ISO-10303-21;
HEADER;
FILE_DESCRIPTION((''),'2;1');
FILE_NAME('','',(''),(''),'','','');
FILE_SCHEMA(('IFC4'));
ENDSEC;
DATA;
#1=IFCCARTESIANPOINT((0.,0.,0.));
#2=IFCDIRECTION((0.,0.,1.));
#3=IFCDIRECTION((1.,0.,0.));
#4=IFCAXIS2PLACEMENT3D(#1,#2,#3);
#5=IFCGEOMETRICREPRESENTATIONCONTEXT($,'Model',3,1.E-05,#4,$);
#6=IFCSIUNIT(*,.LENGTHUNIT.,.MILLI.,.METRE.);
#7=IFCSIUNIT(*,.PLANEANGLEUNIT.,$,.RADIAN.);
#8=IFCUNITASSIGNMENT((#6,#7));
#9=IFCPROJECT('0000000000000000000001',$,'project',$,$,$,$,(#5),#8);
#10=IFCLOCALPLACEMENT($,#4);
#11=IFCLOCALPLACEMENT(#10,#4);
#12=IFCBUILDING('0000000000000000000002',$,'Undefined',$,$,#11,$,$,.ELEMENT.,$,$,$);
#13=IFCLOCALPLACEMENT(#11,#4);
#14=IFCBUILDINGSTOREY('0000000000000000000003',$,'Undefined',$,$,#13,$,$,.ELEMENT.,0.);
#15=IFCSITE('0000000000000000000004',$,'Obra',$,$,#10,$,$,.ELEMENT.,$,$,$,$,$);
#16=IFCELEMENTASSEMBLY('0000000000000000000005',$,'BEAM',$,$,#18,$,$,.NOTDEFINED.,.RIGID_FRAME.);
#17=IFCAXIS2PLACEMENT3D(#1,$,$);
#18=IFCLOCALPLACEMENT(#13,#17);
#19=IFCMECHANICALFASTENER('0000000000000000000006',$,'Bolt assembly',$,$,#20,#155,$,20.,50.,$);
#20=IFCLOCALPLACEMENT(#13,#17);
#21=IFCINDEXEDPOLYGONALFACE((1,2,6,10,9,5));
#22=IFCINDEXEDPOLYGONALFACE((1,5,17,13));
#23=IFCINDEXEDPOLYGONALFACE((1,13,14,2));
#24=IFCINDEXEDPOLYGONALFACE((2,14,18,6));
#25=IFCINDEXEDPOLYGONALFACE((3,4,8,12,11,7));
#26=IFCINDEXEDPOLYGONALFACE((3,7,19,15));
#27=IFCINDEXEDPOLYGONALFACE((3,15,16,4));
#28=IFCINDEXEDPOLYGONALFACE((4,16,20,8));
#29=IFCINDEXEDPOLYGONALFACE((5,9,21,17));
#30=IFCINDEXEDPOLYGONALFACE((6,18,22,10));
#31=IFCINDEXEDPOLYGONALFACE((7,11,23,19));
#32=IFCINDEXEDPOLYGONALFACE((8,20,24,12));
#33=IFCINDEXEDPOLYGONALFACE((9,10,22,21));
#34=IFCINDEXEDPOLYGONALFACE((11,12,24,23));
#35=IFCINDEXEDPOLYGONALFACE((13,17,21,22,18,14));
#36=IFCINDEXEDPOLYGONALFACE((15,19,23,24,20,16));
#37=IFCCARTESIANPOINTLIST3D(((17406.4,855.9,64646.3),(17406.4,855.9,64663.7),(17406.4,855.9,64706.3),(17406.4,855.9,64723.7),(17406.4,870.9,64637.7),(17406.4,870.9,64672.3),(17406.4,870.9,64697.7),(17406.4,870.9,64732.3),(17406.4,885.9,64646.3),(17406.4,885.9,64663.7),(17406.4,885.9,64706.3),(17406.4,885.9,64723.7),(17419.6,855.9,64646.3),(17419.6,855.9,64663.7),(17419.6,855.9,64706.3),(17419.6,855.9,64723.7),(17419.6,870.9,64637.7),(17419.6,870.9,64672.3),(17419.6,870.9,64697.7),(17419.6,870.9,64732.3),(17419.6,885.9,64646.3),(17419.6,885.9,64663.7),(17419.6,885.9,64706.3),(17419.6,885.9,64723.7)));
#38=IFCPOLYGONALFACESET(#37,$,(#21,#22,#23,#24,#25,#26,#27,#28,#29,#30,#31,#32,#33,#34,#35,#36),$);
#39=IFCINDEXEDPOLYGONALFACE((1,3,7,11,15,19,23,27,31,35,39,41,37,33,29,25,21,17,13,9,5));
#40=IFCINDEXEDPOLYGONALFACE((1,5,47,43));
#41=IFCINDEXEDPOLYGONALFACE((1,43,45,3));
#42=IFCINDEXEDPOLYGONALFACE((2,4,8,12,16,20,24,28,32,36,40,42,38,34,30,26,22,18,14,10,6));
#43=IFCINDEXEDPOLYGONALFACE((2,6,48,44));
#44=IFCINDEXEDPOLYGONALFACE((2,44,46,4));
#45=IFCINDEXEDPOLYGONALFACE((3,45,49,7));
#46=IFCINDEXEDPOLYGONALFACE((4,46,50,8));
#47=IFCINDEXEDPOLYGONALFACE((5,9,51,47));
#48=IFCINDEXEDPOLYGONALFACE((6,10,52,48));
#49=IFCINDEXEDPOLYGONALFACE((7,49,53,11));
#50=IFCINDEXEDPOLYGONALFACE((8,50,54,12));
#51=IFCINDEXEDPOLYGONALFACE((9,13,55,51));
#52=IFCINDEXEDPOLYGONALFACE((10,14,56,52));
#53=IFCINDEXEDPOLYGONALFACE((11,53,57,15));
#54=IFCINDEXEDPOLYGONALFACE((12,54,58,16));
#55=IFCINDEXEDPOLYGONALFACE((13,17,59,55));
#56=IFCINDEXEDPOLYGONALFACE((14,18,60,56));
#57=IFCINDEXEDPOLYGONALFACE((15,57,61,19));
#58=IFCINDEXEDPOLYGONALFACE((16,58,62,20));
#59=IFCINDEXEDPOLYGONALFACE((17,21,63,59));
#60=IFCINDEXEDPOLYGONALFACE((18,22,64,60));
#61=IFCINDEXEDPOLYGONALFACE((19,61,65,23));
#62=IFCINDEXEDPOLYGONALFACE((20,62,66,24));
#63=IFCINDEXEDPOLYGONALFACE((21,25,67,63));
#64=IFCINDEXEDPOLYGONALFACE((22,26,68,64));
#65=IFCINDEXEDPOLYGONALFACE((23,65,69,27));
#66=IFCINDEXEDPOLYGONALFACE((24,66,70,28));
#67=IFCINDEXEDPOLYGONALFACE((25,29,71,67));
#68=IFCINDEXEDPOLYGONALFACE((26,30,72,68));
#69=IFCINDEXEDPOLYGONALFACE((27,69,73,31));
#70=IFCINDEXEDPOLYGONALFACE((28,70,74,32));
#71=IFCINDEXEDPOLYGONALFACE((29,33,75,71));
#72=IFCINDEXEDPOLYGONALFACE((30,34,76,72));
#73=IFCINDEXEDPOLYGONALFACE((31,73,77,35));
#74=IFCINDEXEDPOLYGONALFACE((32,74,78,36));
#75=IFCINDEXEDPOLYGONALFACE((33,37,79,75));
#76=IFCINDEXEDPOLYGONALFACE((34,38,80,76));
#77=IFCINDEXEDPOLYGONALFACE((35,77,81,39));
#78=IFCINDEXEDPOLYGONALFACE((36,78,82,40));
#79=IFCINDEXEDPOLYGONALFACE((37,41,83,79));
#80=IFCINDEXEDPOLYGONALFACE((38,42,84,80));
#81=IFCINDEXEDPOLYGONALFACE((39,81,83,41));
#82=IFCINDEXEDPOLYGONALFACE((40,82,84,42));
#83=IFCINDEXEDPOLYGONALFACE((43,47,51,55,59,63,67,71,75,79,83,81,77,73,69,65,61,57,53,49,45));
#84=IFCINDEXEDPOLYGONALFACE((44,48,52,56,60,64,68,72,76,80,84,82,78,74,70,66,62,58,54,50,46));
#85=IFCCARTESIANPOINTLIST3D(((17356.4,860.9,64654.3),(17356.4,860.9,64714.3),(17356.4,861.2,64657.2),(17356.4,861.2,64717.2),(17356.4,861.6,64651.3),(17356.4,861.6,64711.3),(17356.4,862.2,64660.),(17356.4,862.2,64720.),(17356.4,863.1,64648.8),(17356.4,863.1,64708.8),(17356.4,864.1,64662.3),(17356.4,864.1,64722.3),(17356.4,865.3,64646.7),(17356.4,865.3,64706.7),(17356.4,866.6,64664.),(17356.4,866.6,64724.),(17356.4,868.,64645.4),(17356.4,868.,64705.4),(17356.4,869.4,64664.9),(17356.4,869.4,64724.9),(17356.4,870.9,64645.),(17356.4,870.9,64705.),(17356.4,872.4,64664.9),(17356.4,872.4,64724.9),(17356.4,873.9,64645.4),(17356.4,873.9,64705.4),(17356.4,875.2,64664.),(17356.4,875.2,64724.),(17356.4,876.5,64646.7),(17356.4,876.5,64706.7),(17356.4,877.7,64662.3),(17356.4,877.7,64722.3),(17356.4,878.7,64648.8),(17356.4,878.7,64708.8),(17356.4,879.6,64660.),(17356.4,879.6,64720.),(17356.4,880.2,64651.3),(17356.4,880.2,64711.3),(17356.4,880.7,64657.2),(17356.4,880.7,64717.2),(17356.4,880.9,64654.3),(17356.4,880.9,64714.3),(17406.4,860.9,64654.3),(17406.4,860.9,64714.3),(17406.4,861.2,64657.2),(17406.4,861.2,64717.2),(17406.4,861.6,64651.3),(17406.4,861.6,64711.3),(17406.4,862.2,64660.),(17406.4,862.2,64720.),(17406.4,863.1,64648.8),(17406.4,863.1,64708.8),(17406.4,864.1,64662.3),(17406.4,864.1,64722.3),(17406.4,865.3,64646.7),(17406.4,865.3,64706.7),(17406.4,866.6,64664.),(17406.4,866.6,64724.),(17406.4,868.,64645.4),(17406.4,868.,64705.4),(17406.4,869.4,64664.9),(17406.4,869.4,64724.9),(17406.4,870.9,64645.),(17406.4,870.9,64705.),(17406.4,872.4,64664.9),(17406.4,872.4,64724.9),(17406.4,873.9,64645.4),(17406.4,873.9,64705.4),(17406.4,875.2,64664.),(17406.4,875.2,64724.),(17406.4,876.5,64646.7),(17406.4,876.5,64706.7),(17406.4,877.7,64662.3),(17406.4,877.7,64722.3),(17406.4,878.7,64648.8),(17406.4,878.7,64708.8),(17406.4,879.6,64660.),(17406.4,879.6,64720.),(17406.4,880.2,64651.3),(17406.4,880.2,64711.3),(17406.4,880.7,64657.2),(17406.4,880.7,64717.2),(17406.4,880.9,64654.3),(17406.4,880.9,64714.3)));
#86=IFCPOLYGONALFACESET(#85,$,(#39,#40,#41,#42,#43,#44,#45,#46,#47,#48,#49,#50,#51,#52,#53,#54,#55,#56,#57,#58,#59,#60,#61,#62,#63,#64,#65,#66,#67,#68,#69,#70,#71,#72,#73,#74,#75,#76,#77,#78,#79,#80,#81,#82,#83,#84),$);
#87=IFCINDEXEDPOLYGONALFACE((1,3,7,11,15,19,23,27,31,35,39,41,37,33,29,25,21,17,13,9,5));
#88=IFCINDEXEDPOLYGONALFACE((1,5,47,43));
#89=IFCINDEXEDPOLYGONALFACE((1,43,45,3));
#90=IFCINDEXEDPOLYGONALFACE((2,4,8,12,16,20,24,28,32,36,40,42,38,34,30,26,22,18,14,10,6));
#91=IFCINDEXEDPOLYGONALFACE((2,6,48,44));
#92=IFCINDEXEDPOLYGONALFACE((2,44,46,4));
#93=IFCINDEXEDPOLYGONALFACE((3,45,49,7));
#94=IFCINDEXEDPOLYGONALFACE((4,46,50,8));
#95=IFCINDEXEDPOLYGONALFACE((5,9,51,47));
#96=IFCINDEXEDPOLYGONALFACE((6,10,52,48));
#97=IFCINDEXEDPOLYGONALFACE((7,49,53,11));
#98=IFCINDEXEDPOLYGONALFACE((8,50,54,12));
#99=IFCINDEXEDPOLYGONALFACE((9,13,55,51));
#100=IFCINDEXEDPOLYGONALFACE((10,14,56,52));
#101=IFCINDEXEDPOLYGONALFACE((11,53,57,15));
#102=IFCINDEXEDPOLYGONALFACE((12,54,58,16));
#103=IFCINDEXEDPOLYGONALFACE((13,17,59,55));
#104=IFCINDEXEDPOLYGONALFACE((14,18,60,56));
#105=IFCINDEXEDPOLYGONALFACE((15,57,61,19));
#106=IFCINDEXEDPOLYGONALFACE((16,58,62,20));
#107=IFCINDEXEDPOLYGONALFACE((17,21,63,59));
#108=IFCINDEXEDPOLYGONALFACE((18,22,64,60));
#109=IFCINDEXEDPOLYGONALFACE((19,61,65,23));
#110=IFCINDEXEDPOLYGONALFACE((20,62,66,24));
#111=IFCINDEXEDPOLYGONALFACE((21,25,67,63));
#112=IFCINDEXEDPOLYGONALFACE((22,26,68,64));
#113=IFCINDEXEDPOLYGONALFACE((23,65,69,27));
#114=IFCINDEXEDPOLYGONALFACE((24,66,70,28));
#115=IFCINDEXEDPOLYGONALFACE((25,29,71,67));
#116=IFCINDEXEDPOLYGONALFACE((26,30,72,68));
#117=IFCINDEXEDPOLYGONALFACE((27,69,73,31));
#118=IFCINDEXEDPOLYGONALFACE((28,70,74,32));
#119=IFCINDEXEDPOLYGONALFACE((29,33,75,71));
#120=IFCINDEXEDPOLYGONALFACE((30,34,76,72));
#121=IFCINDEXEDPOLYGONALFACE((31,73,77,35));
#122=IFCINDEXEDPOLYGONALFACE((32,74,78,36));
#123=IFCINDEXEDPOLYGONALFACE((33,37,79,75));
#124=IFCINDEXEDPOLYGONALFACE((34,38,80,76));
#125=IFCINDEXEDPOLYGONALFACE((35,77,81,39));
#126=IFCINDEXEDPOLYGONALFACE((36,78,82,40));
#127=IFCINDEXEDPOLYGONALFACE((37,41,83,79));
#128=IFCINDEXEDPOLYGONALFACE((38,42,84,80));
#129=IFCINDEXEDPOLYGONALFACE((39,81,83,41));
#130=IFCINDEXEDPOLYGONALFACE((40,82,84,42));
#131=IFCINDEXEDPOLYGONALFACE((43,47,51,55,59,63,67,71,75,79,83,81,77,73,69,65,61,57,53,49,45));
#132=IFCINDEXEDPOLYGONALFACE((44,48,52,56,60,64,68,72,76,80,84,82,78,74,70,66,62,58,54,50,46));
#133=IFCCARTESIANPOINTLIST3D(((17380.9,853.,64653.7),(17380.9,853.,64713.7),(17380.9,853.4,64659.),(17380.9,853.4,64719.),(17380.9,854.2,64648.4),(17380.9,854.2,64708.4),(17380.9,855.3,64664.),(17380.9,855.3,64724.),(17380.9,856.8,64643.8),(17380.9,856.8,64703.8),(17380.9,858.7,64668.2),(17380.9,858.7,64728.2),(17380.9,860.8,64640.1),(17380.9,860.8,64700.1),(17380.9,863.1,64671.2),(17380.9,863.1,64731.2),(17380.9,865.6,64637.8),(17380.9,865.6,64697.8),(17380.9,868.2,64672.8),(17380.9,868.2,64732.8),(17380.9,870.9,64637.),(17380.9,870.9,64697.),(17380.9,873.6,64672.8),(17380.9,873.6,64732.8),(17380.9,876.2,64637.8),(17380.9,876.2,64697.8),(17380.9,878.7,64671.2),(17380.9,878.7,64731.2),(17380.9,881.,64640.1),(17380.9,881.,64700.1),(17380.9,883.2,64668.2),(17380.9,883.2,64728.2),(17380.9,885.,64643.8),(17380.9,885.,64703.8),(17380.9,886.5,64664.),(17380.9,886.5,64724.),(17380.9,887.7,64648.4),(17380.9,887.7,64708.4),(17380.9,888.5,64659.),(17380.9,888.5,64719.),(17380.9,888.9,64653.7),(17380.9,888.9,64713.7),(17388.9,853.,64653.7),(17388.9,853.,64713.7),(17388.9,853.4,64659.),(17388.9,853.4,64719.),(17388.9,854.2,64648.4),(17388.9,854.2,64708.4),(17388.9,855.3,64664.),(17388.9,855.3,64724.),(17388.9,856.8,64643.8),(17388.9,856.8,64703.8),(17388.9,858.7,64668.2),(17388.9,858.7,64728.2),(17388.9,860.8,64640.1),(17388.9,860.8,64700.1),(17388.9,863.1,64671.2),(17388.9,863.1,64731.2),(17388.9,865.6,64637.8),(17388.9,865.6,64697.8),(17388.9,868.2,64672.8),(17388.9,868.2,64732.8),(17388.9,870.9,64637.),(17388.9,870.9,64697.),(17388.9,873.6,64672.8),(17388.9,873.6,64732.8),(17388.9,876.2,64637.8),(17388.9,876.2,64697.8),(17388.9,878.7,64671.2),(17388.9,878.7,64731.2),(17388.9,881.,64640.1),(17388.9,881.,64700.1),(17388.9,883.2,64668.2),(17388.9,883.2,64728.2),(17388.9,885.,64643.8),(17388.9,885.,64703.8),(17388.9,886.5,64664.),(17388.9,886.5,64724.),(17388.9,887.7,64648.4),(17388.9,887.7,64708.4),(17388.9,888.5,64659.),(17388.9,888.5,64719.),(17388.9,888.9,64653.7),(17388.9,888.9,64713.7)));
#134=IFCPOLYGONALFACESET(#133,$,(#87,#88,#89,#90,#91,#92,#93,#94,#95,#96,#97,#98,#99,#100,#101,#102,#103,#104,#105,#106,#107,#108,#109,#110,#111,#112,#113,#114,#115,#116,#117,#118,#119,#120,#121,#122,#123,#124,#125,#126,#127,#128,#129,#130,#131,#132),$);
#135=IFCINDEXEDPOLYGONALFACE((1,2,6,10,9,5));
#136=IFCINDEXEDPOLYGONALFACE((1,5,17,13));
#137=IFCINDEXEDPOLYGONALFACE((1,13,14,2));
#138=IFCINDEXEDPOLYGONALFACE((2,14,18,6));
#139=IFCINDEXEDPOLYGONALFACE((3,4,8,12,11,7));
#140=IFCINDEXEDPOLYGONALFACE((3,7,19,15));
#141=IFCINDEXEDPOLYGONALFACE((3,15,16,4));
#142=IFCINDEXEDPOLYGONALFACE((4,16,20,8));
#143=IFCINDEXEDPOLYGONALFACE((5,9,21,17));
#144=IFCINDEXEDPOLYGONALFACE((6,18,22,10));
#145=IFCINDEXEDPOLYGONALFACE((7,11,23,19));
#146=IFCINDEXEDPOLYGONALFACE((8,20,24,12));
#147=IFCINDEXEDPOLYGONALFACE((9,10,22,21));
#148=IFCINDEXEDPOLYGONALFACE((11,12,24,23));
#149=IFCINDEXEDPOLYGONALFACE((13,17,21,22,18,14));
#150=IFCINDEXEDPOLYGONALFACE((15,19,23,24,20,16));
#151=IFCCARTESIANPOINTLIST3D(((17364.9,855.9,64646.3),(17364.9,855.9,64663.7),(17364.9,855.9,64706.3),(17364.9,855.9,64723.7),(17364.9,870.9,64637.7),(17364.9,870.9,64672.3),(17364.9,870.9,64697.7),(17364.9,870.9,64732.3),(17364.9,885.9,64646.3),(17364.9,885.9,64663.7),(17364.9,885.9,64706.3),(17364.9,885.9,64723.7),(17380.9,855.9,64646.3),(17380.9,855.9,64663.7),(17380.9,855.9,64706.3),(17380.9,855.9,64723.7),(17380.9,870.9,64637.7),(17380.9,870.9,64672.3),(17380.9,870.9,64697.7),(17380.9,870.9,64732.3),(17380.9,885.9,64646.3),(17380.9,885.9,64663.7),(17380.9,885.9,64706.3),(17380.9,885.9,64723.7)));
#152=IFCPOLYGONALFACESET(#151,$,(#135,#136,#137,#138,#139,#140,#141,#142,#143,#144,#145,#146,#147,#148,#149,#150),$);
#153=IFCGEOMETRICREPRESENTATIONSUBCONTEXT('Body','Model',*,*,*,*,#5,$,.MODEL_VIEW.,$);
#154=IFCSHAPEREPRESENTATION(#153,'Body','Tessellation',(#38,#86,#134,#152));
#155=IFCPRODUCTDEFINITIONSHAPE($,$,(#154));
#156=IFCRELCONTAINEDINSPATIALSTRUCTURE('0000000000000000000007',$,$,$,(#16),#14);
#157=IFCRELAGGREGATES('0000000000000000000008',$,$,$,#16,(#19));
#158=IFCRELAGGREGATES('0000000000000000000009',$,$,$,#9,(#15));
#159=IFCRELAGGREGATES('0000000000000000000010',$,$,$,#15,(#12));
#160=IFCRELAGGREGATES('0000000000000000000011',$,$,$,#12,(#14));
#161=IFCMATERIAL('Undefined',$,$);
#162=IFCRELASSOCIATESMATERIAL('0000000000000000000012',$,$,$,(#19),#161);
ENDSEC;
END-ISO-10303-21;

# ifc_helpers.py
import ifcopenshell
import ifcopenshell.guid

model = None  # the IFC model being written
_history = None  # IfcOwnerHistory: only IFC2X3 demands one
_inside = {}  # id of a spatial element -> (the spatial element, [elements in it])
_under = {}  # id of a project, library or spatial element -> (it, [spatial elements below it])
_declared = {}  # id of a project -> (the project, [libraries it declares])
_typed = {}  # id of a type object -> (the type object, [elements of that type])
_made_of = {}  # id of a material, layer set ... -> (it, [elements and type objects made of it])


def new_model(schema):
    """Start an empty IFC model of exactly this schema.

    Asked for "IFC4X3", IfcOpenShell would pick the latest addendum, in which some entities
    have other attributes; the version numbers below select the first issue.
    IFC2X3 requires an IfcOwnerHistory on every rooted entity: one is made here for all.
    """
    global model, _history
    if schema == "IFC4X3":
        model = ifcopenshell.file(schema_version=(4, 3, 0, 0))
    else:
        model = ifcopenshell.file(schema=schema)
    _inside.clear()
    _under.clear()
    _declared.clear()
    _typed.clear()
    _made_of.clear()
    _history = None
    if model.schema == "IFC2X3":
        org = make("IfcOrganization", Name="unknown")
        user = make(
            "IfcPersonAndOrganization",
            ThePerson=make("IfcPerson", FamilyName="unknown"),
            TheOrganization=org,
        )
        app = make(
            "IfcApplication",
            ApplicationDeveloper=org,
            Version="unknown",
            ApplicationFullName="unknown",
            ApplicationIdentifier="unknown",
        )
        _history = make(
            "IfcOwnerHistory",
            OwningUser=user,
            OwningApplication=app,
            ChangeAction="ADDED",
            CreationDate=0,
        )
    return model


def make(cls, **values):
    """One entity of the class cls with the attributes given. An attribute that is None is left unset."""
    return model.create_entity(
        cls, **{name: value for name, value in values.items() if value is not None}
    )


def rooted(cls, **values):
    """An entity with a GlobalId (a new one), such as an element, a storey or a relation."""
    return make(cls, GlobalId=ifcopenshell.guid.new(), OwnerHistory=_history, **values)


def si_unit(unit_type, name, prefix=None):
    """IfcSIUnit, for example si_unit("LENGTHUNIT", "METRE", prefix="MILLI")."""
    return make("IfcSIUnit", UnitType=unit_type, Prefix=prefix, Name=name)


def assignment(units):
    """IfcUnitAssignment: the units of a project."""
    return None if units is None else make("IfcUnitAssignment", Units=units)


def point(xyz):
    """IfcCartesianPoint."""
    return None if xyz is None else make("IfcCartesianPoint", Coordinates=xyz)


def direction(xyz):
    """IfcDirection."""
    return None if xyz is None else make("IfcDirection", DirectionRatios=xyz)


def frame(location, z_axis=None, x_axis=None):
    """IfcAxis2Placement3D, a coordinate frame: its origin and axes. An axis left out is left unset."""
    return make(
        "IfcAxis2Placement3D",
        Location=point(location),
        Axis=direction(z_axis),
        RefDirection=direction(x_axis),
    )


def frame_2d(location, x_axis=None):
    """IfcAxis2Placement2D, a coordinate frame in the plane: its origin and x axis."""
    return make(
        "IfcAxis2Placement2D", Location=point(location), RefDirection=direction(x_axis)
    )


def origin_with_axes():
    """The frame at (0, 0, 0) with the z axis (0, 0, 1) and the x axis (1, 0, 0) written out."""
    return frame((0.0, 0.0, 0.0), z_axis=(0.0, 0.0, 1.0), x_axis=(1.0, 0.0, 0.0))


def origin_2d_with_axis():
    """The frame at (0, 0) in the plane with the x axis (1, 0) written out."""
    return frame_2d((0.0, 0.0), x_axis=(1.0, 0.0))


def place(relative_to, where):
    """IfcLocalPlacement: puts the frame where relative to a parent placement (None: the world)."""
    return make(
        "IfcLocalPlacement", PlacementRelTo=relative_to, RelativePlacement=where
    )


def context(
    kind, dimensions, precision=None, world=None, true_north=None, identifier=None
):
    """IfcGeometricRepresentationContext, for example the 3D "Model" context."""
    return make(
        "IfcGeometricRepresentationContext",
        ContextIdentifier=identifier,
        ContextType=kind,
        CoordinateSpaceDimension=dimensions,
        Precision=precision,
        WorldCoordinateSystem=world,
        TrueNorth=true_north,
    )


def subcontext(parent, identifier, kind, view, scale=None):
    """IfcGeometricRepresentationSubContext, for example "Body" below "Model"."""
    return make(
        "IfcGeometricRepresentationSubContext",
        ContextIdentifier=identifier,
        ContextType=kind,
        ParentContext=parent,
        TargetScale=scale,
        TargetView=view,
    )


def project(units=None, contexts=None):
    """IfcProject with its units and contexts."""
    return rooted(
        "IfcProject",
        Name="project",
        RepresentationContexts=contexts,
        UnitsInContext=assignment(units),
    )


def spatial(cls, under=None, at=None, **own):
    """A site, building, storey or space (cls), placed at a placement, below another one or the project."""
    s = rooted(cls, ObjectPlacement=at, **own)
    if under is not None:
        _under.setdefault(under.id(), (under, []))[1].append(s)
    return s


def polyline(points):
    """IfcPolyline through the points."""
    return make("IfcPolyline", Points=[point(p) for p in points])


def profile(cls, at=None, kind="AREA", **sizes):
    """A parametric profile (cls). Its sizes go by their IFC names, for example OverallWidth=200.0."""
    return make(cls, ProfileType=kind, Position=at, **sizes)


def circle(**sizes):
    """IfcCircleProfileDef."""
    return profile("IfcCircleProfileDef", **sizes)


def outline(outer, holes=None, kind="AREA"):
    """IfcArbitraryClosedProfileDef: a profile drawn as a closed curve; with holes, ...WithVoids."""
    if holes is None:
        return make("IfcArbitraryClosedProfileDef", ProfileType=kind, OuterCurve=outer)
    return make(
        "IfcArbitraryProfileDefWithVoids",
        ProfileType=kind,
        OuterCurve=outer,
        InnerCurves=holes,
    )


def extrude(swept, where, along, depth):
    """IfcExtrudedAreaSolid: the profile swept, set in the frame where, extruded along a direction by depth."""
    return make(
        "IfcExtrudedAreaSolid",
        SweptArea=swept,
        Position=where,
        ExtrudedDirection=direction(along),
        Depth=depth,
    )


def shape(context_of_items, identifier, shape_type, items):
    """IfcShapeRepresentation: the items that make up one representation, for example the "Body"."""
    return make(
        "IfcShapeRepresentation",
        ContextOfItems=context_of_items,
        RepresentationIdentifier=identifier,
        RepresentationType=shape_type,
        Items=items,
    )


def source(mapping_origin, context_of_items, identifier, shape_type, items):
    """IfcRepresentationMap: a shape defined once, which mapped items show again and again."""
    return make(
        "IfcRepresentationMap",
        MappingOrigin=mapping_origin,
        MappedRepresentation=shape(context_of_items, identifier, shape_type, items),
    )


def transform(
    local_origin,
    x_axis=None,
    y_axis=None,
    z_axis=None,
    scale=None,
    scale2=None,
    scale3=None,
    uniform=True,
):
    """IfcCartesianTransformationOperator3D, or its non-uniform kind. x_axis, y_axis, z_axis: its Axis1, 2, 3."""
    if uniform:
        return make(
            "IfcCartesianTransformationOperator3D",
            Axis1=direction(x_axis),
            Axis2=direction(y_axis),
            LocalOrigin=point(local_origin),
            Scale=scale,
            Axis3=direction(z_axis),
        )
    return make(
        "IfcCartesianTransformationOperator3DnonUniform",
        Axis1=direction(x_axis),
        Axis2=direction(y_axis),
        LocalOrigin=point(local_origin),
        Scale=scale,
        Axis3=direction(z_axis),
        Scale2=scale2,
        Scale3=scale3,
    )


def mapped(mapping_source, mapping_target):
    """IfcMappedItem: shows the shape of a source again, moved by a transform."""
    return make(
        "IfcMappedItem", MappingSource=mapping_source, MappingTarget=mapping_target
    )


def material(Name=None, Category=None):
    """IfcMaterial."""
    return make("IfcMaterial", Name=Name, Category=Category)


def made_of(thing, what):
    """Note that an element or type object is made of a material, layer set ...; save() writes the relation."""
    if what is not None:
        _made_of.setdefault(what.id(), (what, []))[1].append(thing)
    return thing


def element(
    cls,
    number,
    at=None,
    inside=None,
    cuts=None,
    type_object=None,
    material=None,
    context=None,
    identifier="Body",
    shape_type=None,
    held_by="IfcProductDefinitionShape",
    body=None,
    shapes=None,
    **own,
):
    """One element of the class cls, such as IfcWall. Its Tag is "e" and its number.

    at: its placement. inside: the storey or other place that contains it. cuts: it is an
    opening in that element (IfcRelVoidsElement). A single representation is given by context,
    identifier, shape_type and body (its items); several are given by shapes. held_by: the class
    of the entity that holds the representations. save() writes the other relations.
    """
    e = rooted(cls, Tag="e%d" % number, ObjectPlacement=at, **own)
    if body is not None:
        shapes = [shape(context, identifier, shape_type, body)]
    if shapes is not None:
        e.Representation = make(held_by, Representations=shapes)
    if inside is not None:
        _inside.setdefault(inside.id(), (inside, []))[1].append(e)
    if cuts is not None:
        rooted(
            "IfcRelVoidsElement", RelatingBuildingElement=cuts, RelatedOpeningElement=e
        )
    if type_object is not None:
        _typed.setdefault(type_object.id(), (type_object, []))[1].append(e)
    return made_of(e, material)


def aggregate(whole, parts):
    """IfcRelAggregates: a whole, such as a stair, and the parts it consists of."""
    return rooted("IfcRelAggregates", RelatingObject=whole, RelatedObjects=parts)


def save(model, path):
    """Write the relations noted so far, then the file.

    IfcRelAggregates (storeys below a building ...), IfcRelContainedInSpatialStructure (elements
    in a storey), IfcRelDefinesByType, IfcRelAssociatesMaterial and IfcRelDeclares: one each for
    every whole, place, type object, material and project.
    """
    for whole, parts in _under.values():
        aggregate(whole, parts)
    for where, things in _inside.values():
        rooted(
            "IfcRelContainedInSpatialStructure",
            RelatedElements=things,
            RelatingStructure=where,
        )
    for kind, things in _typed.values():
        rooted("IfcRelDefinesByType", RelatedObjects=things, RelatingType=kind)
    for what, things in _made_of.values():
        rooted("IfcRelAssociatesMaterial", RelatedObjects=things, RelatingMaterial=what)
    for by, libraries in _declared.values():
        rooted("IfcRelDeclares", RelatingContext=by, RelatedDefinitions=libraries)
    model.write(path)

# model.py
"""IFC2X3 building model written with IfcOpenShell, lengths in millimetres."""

from ifc_helpers import new_model, si_unit, frame, origin_with_axes, origin_2d_with_axis, place, context, subcontext, project, spatial, polyline, circle, outline, extrude, source, transform, mapped, material, element, aggregate, save


model = new_model("IFC2X3")

# Units and contexts
model_context = context("Model", 3, precision=1e-05, world=origin_with_axes())
body_context = subcontext(model_context, "Body", "Model", "MODEL_VIEW")
ifc_project = project(units=[si_unit("LENGTHUNIT", "METRE", prefix="MILLI"), si_unit("PLANEANGLEUNIT", "RADIAN")], contexts=[model_context])

# Site, building, storey
site_placement = place(None, origin_with_axes())
site = spatial("IfcSite", under=ifc_project, at=site_placement, Name="Obra", CompositionType="ELEMENT")
building_placement = place(site_placement, origin_with_axes())
building = spatial("IfcBuilding", under=site, at=building_placement, Name="Undefined", CompositionType="ELEMENT")
storey_placement = place(building_placement, origin_with_axes())
storey = spatial("IfcBuildingStorey", under=building, at=storey_placement, Name="Undefined", CompositionType="ELEMENT", Elevation=0.0)

# Shared definitions
ifc_material = material(Name="Undefined")

# Element assembly
shared_shape_1 = source(origin_with_axes(), body_context, "Body", "SweptSolid", [
    extrude(outline(polyline([(17.3, 0.0), (8.7, 15.0), (-8.7, 15.0), (-17.3, 0.0), (-8.7, -15.0), (8.7, -15.0), (17.3, 0.0)])), frame((0.0, -27.0, 0.0), z_axis=(0.0, 1.0, 0.0), x_axis=(1.0, 0.0, 0.0)), (0.0, 0.0, 1.0), 13.2),
    extrude(circle(Radius=10.0, at=origin_2d_with_axis()), frame((0.0, -13.8, 0.0), z_axis=(0.0, 1.0, 0.0), x_axis=(1.0, 0.0, 0.0)), (0.0, 0.0, 1.0), 50.0),
    extrude(circle(Radius=18.0, at=origin_2d_with_axis()), frame((0.0, 3.7, 0.0), z_axis=(0.0, 1.0, 0.0), x_axis=(1.0, 0.0, 0.0)), (0.0, 0.0, 1.0), 8.0),
    extrude(outline(polyline([(17.3, 0.0), (8.7, 15.0), (-8.7, 15.0), (-17.3, 0.0), (-8.7, -15.0), (8.7, -15.0), (17.3, 0.0)])), frame((0.0, 11.7, 0.0), z_axis=(0.0, 1.0, 0.0), x_axis=(1.0, 0.0, 0.0)), (0.0, 0.0, 1.0), 16.0),
])
assembly_1_placement = place(storey_placement, origin_with_axes())
assembly_1 = element("IfcElementAssembly", 1, at=assembly_1_placement, inside=storey, Name="BEAM", AssemblyPlace="NOTDEFINED", PredefinedType="RIGID_FRAME")

# Mechanical fastener
mechanical_fastener_1_placement = place(assembly_1_placement, frame((17392.7, 830.9, 64850.0), z_axis=(0.0, 1.0, 0.0), x_axis=(0.0, 0.0, -1.0)))
mechanical_fastener_1 = element("IfcMechanicalFastener", 2, at=mechanical_fastener_1_placement, material=ifc_material, Name="Bolt assembly", NominalDiameter=20.0, NominalLength=50.0, context=body_context, shape_type="MappedRepresentation", body=[
    mapped(shared_shape_1, transform((135.0, 0.0, 40.0))),
    mapped(shared_shape_1, transform((195.0, 0.0, 40.0))),
])
aggregate(assembly_1, [mechanical_fastener_1])

save(model, "model.ifc")
